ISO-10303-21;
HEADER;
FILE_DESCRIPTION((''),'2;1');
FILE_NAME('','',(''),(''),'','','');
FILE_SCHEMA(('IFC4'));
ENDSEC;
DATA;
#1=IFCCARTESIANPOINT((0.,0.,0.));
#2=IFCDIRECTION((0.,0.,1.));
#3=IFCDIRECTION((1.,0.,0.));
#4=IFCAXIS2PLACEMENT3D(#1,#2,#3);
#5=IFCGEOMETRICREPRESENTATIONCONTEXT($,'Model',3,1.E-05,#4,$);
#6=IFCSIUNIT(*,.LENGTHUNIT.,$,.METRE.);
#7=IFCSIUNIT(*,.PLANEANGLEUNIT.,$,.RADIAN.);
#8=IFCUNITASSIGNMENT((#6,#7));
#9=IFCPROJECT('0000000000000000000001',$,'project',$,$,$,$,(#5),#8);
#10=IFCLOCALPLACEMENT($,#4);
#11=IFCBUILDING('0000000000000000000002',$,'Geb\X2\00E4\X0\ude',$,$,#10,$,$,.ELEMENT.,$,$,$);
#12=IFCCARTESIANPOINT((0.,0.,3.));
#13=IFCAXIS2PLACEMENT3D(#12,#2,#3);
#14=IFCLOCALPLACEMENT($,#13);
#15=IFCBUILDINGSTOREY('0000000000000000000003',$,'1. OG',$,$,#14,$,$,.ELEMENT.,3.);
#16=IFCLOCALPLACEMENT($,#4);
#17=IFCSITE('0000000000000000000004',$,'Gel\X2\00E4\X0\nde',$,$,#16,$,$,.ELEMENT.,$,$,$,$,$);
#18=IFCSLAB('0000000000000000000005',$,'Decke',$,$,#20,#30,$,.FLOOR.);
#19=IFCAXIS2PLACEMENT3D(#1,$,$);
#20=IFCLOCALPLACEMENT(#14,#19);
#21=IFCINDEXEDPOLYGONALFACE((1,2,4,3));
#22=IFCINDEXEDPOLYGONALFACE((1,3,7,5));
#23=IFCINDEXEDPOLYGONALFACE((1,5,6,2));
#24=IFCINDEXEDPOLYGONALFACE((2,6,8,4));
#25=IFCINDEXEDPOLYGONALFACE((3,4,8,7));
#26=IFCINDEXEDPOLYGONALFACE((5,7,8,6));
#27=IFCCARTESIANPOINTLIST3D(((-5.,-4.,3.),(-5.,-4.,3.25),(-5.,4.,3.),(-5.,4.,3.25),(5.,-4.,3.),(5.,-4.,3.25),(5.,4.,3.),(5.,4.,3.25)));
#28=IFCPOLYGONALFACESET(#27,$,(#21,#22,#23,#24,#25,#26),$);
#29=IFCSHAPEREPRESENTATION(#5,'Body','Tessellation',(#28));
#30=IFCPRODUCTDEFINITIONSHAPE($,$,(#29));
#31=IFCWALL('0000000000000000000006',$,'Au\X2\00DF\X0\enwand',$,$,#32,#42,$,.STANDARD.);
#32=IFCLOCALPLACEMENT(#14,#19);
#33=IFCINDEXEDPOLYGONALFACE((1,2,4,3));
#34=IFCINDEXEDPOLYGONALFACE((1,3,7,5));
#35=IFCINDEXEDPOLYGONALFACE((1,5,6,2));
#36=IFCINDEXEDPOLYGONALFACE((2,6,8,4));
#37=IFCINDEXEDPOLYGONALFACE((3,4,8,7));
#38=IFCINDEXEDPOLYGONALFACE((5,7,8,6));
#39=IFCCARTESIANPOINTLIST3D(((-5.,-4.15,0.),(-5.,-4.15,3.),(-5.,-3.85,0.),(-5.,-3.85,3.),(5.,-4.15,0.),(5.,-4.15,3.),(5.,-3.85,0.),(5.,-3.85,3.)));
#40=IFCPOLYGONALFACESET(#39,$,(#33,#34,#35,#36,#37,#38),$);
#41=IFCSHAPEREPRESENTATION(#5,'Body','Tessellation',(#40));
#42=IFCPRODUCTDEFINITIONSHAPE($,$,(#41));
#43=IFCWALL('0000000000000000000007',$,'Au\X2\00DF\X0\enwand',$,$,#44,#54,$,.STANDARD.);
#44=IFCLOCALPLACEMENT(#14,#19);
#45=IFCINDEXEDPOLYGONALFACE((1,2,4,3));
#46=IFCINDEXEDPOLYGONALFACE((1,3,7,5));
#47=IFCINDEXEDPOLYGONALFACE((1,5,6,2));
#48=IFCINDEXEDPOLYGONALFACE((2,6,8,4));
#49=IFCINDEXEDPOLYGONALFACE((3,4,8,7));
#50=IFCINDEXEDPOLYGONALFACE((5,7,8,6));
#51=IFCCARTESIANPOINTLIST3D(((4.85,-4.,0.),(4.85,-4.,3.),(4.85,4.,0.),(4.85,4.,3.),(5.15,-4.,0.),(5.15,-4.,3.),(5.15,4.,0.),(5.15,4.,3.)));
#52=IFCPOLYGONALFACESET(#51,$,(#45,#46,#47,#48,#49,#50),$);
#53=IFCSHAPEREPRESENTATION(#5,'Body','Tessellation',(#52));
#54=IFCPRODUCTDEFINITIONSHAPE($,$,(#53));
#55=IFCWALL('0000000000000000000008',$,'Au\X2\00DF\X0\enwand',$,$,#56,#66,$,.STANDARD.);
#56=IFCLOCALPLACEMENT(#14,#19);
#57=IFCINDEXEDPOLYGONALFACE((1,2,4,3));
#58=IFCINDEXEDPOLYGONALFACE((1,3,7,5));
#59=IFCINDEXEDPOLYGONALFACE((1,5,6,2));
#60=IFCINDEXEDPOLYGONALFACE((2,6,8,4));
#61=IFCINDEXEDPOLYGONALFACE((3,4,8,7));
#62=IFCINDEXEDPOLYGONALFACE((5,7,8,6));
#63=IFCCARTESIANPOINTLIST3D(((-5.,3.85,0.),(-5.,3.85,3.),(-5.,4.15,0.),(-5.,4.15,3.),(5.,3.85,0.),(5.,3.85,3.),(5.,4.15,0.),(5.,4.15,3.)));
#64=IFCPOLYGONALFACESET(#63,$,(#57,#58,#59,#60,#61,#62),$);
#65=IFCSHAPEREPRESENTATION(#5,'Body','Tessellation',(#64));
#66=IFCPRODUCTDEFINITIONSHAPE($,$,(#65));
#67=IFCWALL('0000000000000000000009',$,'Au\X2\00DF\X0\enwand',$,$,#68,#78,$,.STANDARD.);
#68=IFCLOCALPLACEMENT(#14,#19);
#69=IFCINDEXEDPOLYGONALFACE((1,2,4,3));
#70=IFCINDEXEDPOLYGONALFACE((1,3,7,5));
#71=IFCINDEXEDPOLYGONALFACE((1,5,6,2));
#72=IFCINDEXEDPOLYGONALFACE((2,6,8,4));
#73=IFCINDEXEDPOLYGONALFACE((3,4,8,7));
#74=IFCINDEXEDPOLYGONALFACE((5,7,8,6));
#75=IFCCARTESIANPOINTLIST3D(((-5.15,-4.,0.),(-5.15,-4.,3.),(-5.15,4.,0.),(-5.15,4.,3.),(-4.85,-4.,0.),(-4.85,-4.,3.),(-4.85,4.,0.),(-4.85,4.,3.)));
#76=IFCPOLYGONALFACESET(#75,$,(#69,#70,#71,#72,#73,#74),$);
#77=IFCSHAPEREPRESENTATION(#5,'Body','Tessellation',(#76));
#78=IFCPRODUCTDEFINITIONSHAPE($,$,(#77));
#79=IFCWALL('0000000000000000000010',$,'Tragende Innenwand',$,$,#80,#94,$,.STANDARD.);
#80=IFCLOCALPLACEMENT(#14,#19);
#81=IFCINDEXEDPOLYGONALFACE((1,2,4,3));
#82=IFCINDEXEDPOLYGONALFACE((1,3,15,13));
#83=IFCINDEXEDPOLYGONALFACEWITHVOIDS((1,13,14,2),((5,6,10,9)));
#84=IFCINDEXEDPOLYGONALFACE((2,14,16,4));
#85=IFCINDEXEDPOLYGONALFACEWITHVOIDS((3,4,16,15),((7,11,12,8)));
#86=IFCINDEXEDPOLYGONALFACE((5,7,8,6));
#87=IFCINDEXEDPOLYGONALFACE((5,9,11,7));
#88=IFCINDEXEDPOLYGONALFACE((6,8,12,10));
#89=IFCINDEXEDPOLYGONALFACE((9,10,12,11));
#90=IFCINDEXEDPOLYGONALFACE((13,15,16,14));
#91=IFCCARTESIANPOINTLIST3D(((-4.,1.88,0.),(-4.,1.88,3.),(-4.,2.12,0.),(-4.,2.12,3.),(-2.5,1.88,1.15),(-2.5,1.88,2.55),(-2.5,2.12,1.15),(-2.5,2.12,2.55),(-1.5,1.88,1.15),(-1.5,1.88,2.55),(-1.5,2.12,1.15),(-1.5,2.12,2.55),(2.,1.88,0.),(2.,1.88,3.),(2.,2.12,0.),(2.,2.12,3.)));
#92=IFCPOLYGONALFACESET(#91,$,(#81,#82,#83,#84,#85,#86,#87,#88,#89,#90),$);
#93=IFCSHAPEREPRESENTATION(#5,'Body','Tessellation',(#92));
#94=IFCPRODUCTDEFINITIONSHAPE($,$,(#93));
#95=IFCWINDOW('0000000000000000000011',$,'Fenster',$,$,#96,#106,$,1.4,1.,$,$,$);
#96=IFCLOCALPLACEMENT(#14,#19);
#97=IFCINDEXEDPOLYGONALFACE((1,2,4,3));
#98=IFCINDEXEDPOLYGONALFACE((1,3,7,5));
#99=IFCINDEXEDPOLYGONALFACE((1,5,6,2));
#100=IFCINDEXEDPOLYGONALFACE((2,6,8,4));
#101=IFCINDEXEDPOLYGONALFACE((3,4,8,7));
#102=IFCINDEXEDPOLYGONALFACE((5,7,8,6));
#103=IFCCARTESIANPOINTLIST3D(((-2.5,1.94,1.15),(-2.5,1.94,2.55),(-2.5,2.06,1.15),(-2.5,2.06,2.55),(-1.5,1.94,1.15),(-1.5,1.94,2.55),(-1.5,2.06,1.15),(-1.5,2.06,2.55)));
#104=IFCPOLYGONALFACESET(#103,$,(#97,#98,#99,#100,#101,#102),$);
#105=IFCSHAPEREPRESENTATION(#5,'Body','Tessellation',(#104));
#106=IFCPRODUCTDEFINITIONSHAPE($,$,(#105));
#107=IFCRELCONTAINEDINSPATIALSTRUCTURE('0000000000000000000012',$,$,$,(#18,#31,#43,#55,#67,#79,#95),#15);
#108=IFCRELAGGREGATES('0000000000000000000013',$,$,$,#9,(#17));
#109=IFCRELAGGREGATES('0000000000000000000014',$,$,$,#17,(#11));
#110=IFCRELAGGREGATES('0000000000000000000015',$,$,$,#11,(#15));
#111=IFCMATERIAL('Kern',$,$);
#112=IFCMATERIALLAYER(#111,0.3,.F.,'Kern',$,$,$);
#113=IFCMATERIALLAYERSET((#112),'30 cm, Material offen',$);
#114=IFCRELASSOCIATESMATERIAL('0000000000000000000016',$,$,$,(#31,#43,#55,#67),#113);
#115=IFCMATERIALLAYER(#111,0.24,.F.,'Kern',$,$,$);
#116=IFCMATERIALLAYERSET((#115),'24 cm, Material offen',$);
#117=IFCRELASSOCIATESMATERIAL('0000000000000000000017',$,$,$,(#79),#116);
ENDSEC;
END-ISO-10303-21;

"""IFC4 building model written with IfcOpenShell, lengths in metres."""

from ifc_helpers import new_model, si_unit, frame, origin_with_axes, origin_2d, place, context, project, spatial, polyline, rectangle, outline, extrude, material, layer, layer_set, element, fill, save


model = new_model("IFC4")

# Units and contexts
model_context = context("Model", 3, precision=1e-05, world=origin_with_axes())
ifc_project = project(units=[si_unit("LENGTHUNIT", "METRE"), si_unit("PLANEANGLEUNIT", "RADIAN")], contexts=[model_context])

# Site, building, storey
site_placement = place(None, origin_with_axes())
site = spatial("IfcSite", under=ifc_project, at=site_placement, Name="Gelände", CompositionType="ELEMENT")
building_placement = place(None, origin_with_axes())
building = spatial("IfcBuilding", under=site, at=building_placement, Name="Gebäude", CompositionType="ELEMENT")
storey_placement = place(None, frame((0.0, 0.0, 3.0), z_axis=(0.0, 0.0, 1.0), x_axis=(1.0, 0.0, 0.0)))
storey = spatial("IfcBuildingStorey", under=building, at=storey_placement, Name="1. OG", CompositionType="ELEMENT", Elevation=3.0)

# Slab
slab_placement = place(None, frame((0.0, 0.0, 6.0), z_axis=(0.0, 0.0, 1.0), x_axis=(1.0, 0.0, 0.0)))
element("IfcSlab", 1, at=slab_placement, inside=storey, Name="Decke", PredefinedType="FLOOR", context=model_context, shape_type="SweptSolid", body=[
    extrude(outline(polyline([(-5.0, -4.0), (5.0, -4.0), (5.0, 4.0), (-5.0, 4.0), (-5.0, -4.0)])), origin_with_axes(), (0.0, 0.0, 1.0), 0.25),
])

# Walls
ifc_material = material(Name="Kern")
ifc_layer_1 = layer(ifc_material, 0.3, ventilated=False, Name="Kern")
ifc_layer_set_1 = layer_set([ifc_layer_1], Name="30 cm, Material offen")
wall_1_placement = place(None, frame((0.0, -4.0, 3.0), z_axis=(0.0, 0.0, 1.0), x_axis=(1.0, 0.0, 0.0)))
element("IfcWall", 2, at=wall_1_placement, inside=storey, material=ifc_layer_set_1, Name="Außenwand", PredefinedType="STANDARD", context=model_context, shape_type="SweptSolid", body=[
    extrude(rectangle(XDim=10.0, YDim=0.3, at=origin_2d()), origin_with_axes(), (0.0, 0.0, 1.0), 3.0),
])
wall_2_placement = place(None, frame((5.0, 0.0, 3.0), z_axis=(0.0, 0.0, 1.0), x_axis=(0.0, 1.0, 0.0)))
element("IfcWall", 3, at=wall_2_placement, inside=storey, material=ifc_layer_set_1, Name="Außenwand", PredefinedType="STANDARD", context=model_context, shape_type="SweptSolid", body=[
    extrude(rectangle(XDim=8.0, YDim=0.3, at=origin_2d()), origin_with_axes(), (0.0, 0.0, 1.0), 3.0),
])
wall_3_placement = place(None, frame((0.0, 4.0, 3.0), z_axis=(0.0, 0.0, 1.0), x_axis=(-1.0, 0.0, 0.0)))
element("IfcWall", 4, at=wall_3_placement, inside=storey, material=ifc_layer_set_1, Name="Außenwand", PredefinedType="STANDARD", context=model_context, shape_type="SweptSolid", body=[
    extrude(rectangle(XDim=10.0, YDim=0.3, at=origin_2d()), origin_with_axes(), (0.0, 0.0, 1.0), 3.0),
])
wall_4_placement = place(None, frame((-5.0, 0.0, 3.0), z_axis=(0.0, 0.0, 1.0), x_axis=(0.0, -1.0, 0.0)))
element("IfcWall", 5, at=wall_4_placement, inside=storey, material=ifc_layer_set_1, Name="Außenwand", PredefinedType="STANDARD", context=model_context, shape_type="SweptSolid", body=[
    extrude(rectangle(XDim=8.0, YDim=0.3, at=origin_2d()), origin_with_axes(), (0.0, 0.0, 1.0), 3.0),
])

# Wall, opening, window
ifc_layer_2 = layer(ifc_material, 0.24, ventilated=False, Name="Kern")
ifc_layer_set_2 = layer_set([ifc_layer_2], Name="24 cm, Material offen")
wall_5_placement = place(None, frame((-1.0, 2.0, 3.0), z_axis=(0.0, 0.0, 1.0), x_axis=(1.0, 0.0, 0.0)))
wall_5 = element("IfcWall", 6, at=wall_5_placement, inside=storey, material=ifc_layer_set_2, Name="Tragende Innenwand", PredefinedType="STANDARD", context=model_context, shape_type="SweptSolid", body=[
    extrude(rectangle(XDim=6.0, YDim=0.24, at=origin_2d()), origin_with_axes(), (0.0, 0.0, 1.0), 3.0),
])
opening_placement = place(wall_5_placement, frame((-1.0, 0.0, 1.15), z_axis=(0.0, 0.0, 1.0), x_axis=(1.0, 0.0, 0.0)))
opening = element("IfcOpeningElement", 7, at=opening_placement, cuts=wall_5, PredefinedType="OPENING", context=model_context, shape_type="SweptSolid", body=[
    extrude(rectangle(XDim=1.0, YDim=0.28, at=origin_2d()), origin_with_axes(), (0.0, 0.0, 1.0), 1.4),
])
window_placement = place(opening_placement, origin_with_axes())
window = element("IfcWindow", 8, at=window_placement, inside=storey, Name="Fenster", OverallHeight=1.4, OverallWidth=1.0, context=model_context, shape_type="SweptSolid", body=[
    extrude(rectangle(XDim=1.0, YDim=0.12, at=origin_2d()), origin_with_axes(), (0.0, 0.0, 1.0), 1.4),
])
fill(opening, window)

save(model, "model.ifc")
